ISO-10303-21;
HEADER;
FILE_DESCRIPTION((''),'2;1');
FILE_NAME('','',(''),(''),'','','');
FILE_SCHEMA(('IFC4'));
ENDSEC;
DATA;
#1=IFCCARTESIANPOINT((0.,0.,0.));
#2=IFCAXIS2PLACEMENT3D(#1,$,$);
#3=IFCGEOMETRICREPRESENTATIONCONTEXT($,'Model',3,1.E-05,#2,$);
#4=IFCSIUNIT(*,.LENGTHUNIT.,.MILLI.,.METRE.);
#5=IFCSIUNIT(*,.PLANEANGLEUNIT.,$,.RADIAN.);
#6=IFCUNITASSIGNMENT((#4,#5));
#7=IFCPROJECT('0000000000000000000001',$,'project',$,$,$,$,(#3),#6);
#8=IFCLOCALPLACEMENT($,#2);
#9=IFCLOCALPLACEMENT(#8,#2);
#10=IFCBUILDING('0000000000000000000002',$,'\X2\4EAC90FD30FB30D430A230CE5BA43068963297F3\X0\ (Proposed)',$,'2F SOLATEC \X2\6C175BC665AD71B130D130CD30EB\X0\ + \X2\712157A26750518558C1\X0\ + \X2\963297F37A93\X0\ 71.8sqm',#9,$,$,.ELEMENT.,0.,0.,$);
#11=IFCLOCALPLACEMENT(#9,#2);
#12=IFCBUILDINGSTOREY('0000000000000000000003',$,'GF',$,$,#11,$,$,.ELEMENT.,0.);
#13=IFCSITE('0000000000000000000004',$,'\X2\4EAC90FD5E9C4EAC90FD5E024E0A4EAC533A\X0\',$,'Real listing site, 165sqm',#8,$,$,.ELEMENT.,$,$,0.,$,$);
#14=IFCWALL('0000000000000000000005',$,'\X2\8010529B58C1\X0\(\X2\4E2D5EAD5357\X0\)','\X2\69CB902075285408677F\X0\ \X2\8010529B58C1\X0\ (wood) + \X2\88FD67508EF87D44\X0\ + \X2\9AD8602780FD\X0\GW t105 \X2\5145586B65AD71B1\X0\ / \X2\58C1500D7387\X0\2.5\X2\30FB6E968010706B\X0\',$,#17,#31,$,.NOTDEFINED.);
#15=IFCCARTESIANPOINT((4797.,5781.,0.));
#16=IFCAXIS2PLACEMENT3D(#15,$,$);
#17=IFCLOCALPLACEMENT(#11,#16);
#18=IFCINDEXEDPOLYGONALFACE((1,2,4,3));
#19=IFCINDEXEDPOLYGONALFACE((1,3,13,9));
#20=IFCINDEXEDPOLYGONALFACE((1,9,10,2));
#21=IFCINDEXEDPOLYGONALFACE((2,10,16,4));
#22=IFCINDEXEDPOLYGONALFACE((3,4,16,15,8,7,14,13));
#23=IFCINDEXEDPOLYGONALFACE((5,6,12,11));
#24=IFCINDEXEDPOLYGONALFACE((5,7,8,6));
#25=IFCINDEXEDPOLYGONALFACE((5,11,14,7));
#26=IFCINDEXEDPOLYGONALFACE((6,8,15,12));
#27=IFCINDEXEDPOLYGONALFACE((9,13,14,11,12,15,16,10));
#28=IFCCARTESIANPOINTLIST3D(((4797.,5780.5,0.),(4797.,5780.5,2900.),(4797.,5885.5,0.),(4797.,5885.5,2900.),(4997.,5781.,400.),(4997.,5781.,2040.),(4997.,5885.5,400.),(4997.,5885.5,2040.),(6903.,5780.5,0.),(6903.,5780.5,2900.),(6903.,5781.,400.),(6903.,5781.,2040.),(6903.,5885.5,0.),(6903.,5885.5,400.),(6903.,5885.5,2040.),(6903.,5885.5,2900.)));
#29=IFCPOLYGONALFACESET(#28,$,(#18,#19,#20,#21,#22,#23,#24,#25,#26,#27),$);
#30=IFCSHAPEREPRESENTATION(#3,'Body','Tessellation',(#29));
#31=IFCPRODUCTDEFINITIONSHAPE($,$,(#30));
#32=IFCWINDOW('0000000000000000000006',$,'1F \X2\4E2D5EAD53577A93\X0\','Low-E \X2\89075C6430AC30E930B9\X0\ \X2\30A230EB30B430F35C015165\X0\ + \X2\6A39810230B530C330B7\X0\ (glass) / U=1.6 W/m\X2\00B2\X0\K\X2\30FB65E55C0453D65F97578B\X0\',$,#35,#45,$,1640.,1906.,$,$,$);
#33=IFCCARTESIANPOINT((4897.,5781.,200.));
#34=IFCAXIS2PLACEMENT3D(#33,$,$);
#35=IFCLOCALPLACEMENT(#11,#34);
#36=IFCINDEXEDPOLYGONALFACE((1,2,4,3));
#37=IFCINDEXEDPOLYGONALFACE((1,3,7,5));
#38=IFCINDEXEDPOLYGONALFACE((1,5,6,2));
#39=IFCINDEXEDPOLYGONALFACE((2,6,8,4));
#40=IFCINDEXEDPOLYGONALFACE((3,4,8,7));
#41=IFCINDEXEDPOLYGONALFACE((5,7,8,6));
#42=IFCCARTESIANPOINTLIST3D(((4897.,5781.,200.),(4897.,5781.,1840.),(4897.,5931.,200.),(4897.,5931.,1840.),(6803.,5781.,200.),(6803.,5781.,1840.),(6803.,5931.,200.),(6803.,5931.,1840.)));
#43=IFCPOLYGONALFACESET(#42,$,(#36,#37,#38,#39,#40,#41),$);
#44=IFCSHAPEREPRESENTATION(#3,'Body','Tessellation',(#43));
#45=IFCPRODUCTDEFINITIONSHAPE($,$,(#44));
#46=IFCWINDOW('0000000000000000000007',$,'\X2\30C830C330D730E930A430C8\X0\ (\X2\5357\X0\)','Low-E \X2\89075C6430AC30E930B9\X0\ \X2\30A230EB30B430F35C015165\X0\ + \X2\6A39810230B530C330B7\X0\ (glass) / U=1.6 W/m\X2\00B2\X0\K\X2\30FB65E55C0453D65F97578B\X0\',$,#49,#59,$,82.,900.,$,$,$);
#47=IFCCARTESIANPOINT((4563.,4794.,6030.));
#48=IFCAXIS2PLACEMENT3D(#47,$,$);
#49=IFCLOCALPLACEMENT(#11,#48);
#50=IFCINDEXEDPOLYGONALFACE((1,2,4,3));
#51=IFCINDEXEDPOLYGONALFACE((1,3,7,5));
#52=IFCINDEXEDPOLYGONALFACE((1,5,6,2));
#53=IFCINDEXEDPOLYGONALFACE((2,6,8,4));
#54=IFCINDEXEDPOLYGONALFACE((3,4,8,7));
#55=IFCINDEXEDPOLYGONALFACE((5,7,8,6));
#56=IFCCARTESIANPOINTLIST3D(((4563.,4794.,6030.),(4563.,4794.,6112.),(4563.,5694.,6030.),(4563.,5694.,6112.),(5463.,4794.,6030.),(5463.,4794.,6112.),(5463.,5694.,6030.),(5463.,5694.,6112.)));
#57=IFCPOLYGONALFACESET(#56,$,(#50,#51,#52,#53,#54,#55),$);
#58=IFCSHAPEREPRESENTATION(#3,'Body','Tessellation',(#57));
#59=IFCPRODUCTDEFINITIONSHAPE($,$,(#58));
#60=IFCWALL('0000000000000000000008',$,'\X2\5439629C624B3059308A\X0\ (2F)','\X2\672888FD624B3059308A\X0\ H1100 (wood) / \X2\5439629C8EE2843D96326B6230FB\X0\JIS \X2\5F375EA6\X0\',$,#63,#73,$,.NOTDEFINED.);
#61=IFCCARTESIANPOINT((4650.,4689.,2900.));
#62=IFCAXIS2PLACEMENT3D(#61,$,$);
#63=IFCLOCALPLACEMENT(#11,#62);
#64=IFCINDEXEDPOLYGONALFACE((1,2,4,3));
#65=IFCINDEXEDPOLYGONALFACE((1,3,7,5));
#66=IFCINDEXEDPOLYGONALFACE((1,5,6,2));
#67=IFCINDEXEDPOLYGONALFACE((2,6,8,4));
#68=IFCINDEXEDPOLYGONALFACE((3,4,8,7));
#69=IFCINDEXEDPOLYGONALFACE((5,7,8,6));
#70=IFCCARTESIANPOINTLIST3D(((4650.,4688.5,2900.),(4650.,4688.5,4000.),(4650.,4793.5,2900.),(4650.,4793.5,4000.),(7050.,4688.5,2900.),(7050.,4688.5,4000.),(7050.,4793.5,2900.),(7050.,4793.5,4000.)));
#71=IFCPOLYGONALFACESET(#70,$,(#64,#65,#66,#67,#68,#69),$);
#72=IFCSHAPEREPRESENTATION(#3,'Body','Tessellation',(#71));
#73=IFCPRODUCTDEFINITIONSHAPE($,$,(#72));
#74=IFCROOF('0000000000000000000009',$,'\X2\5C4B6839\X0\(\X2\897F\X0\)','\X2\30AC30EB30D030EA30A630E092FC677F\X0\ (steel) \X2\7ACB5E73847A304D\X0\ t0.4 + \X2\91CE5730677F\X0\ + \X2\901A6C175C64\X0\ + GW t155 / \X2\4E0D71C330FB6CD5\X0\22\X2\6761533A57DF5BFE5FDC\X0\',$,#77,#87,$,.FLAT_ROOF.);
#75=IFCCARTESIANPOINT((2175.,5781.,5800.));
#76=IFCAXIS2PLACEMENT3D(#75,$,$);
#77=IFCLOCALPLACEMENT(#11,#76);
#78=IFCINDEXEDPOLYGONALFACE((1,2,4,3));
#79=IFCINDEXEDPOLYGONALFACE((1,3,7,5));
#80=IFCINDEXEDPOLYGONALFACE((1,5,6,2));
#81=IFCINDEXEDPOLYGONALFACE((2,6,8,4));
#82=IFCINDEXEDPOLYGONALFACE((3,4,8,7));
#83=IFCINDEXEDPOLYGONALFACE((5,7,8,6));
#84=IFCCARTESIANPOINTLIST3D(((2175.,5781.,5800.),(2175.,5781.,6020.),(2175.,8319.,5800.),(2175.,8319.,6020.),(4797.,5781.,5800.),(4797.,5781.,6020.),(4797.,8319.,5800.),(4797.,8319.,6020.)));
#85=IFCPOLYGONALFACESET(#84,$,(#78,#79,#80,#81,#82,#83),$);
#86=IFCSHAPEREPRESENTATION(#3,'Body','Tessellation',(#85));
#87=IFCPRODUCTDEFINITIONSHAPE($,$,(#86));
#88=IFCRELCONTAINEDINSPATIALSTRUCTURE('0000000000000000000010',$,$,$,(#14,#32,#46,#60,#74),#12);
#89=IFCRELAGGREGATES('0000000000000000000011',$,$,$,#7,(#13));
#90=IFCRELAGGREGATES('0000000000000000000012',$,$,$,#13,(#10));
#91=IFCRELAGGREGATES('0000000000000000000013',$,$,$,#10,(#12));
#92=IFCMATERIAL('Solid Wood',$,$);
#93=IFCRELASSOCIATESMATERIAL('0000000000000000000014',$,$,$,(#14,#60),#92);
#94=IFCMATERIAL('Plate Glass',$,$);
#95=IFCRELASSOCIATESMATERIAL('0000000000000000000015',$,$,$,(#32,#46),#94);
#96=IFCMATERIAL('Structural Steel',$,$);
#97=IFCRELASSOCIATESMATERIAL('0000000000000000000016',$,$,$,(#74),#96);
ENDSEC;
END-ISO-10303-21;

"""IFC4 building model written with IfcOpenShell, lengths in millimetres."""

from ifc_helpers import new_model, si_unit, frame, frame_2d, origin, place, context, project, spatial, rectangle, extrude, material, element, fill, save


model = new_model("IFC4")

# Units and contexts
model_context = context("Model", 3, precision=1e-05, world=origin())
ifc_project = project(units=[si_unit("LENGTHUNIT", "METRE", prefix="MILLI"), si_unit("PLANEANGLEUNIT", "RADIAN")], contexts=[model_context])

# Site, building, storey
site_placement = place(None, origin())
site = spatial("IfcSite", under=ifc_project, at=site_placement, Name="京都府京都市上京区", ObjectType="Real listing site, 165sqm", CompositionType="ELEMENT", RefElevation=0.0)
building_placement = place(site_placement, origin())
building = spatial("IfcBuilding", under=site, at=building_placement, Name="京都・ピアノ室と防音 (Proposed)", ObjectType="2F SOLATEC 気密断熱パネル + 無垢材内壁 + 防音窓 71.8sqm", CompositionType="ELEMENT", ElevationOfRefHeight=0.0, ElevationOfTerrain=0.0)
storey_placement = place(building_placement, origin())
storey = spatial("IfcBuildingStorey", under=building, at=storey_placement, Name="GF", CompositionType="ELEMENT", Elevation=0.0)

# Shared definitions
ifc_material_1 = material(Name="Solid Wood")

# Wall, opening, window
wall_1_placement = place(storey_placement, frame((4797.0, 5781.0, 0.0)))
wall_1 = element("IfcWall", 1, at=wall_1_placement, inside=storey, material=ifc_material_1, Name="耐力壁(中庭南)", Description="構造用合板 耐力壁 (wood) + 製材軸組 + 高性能GW t105 充填断熱 / 壁倍率2.5・準耐火", PredefinedType="NOTDEFINED", context=model_context, shape_type="SweptSolid", body=[
    extrude(rectangle(XDim=2106.0, YDim=105.0, at=frame_2d((1053.0, 52.0))), frame((4797.0, 5781.0, 0.0)), (0.0, 0.0, 1.0), 2900.0),
])
opening_placement = place(storey_placement, frame((4897.0, 5781.0, 200.0)))
opening = element("IfcOpeningElement", 2, at=opening_placement, cuts=wall_1, PredefinedType="NOTDEFINED", context=model_context, shape_type="SweptSolid", body=[
    extrude(rectangle(XDim=1906.0, YDim=150.0, at=frame_2d((953.0, 75.0))), frame((4897.0, 5781.0, 200.0)), (0.0, 0.0, 1.0), 1640.0),
])
ifc_material_2 = material(Name="Plate Glass")
window_1_placement = place(storey_placement, frame((4897.0, 5781.0, 200.0)))
window_1 = element("IfcWindow", 3, at=window_1_placement, inside=storey, material=ifc_material_2, Name="1F 中庭南窓", Description="Low-E 複層ガラス アルゴン封入 + 樹脂サッシ (glass) / U=1.6 W/m²K・日射取得型", OverallHeight=1640.0, OverallWidth=1906.0, context=model_context, shape_type="SweptSolid", body=[
    extrude(rectangle(XDim=1906.0, YDim=150.0, at=frame_2d((953.0, 75.0))), frame((4897.0, 5781.0, 200.0)), (0.0, 0.0, 1.0), 1640.0),
])
fill(opening, window_1)

# Window
window_2_placement = place(storey_placement, frame((4563.0, 4794.0, 6030.0)))
element("IfcWindow", 4, at=window_2_placement, inside=storey, material=ifc_material_2, Name="トップライト (南)", Description="Low-E 複層ガラス アルゴン封入 + 樹脂サッシ (glass) / U=1.6 W/m²K・日射取得型", OverallHeight=82.0, OverallWidth=900.0, context=model_context, shape_type="SweptSolid", body=[
    extrude(rectangle(XDim=900.0, YDim=900.0, at=frame_2d((450.0, 450.0))), frame((4563.0, 4794.0, 6030.0)), (0.0, 0.0, 1.0), 82.0),
])

# Wall
wall_2_placement = place(storey_placement, frame((4650.0, 4689.0, 2900.0)))
element("IfcWall", 5, at=wall_2_placement, inside=storey, material=ifc_material_1, Name="吹抜手すり (2F)", Description="木製手すり H1100 (wood) / 吹抜転落防止・JIS 強度", PredefinedType="NOTDEFINED", context=model_context, shape_type="SweptSolid", body=[
    extrude(rectangle(XDim=2400.0, YDim=105.0, at=frame_2d((1200.0, 52.0))), frame((4650.0, 4689.0, 2900.0)), (0.0, 0.0, 1.0), 1100.0),
])

# Roof
ifc_material_3 = material(Name="Structural Steel")
for number, where, name in (
    (6, (2175.0, 5781.0, 5800.0), "屋根(西)"),
):
    element("IfcRoof", number, at=place(storey_placement, frame(where)), inside=storey, material=ifc_material_3, Name=name, Description="ガルバリウム鋼板 (steel) 立平葺き t0.4 + 野地板 + 通気層 + GW t155 / 不燃・法22条区域対応", PredefinedType="FLAT_ROOF", context=model_context, shape_type="SweptSolid", body=[
        extrude(rectangle(XDim=2622.0, YDim=2538.0, at=frame_2d((1311.0, 1269.0))), frame((2175.0, 5781.0, 5800.0)), (0.0, 0.0, 1.0), 220.0),
    ])

save(model, "model.ifc")
